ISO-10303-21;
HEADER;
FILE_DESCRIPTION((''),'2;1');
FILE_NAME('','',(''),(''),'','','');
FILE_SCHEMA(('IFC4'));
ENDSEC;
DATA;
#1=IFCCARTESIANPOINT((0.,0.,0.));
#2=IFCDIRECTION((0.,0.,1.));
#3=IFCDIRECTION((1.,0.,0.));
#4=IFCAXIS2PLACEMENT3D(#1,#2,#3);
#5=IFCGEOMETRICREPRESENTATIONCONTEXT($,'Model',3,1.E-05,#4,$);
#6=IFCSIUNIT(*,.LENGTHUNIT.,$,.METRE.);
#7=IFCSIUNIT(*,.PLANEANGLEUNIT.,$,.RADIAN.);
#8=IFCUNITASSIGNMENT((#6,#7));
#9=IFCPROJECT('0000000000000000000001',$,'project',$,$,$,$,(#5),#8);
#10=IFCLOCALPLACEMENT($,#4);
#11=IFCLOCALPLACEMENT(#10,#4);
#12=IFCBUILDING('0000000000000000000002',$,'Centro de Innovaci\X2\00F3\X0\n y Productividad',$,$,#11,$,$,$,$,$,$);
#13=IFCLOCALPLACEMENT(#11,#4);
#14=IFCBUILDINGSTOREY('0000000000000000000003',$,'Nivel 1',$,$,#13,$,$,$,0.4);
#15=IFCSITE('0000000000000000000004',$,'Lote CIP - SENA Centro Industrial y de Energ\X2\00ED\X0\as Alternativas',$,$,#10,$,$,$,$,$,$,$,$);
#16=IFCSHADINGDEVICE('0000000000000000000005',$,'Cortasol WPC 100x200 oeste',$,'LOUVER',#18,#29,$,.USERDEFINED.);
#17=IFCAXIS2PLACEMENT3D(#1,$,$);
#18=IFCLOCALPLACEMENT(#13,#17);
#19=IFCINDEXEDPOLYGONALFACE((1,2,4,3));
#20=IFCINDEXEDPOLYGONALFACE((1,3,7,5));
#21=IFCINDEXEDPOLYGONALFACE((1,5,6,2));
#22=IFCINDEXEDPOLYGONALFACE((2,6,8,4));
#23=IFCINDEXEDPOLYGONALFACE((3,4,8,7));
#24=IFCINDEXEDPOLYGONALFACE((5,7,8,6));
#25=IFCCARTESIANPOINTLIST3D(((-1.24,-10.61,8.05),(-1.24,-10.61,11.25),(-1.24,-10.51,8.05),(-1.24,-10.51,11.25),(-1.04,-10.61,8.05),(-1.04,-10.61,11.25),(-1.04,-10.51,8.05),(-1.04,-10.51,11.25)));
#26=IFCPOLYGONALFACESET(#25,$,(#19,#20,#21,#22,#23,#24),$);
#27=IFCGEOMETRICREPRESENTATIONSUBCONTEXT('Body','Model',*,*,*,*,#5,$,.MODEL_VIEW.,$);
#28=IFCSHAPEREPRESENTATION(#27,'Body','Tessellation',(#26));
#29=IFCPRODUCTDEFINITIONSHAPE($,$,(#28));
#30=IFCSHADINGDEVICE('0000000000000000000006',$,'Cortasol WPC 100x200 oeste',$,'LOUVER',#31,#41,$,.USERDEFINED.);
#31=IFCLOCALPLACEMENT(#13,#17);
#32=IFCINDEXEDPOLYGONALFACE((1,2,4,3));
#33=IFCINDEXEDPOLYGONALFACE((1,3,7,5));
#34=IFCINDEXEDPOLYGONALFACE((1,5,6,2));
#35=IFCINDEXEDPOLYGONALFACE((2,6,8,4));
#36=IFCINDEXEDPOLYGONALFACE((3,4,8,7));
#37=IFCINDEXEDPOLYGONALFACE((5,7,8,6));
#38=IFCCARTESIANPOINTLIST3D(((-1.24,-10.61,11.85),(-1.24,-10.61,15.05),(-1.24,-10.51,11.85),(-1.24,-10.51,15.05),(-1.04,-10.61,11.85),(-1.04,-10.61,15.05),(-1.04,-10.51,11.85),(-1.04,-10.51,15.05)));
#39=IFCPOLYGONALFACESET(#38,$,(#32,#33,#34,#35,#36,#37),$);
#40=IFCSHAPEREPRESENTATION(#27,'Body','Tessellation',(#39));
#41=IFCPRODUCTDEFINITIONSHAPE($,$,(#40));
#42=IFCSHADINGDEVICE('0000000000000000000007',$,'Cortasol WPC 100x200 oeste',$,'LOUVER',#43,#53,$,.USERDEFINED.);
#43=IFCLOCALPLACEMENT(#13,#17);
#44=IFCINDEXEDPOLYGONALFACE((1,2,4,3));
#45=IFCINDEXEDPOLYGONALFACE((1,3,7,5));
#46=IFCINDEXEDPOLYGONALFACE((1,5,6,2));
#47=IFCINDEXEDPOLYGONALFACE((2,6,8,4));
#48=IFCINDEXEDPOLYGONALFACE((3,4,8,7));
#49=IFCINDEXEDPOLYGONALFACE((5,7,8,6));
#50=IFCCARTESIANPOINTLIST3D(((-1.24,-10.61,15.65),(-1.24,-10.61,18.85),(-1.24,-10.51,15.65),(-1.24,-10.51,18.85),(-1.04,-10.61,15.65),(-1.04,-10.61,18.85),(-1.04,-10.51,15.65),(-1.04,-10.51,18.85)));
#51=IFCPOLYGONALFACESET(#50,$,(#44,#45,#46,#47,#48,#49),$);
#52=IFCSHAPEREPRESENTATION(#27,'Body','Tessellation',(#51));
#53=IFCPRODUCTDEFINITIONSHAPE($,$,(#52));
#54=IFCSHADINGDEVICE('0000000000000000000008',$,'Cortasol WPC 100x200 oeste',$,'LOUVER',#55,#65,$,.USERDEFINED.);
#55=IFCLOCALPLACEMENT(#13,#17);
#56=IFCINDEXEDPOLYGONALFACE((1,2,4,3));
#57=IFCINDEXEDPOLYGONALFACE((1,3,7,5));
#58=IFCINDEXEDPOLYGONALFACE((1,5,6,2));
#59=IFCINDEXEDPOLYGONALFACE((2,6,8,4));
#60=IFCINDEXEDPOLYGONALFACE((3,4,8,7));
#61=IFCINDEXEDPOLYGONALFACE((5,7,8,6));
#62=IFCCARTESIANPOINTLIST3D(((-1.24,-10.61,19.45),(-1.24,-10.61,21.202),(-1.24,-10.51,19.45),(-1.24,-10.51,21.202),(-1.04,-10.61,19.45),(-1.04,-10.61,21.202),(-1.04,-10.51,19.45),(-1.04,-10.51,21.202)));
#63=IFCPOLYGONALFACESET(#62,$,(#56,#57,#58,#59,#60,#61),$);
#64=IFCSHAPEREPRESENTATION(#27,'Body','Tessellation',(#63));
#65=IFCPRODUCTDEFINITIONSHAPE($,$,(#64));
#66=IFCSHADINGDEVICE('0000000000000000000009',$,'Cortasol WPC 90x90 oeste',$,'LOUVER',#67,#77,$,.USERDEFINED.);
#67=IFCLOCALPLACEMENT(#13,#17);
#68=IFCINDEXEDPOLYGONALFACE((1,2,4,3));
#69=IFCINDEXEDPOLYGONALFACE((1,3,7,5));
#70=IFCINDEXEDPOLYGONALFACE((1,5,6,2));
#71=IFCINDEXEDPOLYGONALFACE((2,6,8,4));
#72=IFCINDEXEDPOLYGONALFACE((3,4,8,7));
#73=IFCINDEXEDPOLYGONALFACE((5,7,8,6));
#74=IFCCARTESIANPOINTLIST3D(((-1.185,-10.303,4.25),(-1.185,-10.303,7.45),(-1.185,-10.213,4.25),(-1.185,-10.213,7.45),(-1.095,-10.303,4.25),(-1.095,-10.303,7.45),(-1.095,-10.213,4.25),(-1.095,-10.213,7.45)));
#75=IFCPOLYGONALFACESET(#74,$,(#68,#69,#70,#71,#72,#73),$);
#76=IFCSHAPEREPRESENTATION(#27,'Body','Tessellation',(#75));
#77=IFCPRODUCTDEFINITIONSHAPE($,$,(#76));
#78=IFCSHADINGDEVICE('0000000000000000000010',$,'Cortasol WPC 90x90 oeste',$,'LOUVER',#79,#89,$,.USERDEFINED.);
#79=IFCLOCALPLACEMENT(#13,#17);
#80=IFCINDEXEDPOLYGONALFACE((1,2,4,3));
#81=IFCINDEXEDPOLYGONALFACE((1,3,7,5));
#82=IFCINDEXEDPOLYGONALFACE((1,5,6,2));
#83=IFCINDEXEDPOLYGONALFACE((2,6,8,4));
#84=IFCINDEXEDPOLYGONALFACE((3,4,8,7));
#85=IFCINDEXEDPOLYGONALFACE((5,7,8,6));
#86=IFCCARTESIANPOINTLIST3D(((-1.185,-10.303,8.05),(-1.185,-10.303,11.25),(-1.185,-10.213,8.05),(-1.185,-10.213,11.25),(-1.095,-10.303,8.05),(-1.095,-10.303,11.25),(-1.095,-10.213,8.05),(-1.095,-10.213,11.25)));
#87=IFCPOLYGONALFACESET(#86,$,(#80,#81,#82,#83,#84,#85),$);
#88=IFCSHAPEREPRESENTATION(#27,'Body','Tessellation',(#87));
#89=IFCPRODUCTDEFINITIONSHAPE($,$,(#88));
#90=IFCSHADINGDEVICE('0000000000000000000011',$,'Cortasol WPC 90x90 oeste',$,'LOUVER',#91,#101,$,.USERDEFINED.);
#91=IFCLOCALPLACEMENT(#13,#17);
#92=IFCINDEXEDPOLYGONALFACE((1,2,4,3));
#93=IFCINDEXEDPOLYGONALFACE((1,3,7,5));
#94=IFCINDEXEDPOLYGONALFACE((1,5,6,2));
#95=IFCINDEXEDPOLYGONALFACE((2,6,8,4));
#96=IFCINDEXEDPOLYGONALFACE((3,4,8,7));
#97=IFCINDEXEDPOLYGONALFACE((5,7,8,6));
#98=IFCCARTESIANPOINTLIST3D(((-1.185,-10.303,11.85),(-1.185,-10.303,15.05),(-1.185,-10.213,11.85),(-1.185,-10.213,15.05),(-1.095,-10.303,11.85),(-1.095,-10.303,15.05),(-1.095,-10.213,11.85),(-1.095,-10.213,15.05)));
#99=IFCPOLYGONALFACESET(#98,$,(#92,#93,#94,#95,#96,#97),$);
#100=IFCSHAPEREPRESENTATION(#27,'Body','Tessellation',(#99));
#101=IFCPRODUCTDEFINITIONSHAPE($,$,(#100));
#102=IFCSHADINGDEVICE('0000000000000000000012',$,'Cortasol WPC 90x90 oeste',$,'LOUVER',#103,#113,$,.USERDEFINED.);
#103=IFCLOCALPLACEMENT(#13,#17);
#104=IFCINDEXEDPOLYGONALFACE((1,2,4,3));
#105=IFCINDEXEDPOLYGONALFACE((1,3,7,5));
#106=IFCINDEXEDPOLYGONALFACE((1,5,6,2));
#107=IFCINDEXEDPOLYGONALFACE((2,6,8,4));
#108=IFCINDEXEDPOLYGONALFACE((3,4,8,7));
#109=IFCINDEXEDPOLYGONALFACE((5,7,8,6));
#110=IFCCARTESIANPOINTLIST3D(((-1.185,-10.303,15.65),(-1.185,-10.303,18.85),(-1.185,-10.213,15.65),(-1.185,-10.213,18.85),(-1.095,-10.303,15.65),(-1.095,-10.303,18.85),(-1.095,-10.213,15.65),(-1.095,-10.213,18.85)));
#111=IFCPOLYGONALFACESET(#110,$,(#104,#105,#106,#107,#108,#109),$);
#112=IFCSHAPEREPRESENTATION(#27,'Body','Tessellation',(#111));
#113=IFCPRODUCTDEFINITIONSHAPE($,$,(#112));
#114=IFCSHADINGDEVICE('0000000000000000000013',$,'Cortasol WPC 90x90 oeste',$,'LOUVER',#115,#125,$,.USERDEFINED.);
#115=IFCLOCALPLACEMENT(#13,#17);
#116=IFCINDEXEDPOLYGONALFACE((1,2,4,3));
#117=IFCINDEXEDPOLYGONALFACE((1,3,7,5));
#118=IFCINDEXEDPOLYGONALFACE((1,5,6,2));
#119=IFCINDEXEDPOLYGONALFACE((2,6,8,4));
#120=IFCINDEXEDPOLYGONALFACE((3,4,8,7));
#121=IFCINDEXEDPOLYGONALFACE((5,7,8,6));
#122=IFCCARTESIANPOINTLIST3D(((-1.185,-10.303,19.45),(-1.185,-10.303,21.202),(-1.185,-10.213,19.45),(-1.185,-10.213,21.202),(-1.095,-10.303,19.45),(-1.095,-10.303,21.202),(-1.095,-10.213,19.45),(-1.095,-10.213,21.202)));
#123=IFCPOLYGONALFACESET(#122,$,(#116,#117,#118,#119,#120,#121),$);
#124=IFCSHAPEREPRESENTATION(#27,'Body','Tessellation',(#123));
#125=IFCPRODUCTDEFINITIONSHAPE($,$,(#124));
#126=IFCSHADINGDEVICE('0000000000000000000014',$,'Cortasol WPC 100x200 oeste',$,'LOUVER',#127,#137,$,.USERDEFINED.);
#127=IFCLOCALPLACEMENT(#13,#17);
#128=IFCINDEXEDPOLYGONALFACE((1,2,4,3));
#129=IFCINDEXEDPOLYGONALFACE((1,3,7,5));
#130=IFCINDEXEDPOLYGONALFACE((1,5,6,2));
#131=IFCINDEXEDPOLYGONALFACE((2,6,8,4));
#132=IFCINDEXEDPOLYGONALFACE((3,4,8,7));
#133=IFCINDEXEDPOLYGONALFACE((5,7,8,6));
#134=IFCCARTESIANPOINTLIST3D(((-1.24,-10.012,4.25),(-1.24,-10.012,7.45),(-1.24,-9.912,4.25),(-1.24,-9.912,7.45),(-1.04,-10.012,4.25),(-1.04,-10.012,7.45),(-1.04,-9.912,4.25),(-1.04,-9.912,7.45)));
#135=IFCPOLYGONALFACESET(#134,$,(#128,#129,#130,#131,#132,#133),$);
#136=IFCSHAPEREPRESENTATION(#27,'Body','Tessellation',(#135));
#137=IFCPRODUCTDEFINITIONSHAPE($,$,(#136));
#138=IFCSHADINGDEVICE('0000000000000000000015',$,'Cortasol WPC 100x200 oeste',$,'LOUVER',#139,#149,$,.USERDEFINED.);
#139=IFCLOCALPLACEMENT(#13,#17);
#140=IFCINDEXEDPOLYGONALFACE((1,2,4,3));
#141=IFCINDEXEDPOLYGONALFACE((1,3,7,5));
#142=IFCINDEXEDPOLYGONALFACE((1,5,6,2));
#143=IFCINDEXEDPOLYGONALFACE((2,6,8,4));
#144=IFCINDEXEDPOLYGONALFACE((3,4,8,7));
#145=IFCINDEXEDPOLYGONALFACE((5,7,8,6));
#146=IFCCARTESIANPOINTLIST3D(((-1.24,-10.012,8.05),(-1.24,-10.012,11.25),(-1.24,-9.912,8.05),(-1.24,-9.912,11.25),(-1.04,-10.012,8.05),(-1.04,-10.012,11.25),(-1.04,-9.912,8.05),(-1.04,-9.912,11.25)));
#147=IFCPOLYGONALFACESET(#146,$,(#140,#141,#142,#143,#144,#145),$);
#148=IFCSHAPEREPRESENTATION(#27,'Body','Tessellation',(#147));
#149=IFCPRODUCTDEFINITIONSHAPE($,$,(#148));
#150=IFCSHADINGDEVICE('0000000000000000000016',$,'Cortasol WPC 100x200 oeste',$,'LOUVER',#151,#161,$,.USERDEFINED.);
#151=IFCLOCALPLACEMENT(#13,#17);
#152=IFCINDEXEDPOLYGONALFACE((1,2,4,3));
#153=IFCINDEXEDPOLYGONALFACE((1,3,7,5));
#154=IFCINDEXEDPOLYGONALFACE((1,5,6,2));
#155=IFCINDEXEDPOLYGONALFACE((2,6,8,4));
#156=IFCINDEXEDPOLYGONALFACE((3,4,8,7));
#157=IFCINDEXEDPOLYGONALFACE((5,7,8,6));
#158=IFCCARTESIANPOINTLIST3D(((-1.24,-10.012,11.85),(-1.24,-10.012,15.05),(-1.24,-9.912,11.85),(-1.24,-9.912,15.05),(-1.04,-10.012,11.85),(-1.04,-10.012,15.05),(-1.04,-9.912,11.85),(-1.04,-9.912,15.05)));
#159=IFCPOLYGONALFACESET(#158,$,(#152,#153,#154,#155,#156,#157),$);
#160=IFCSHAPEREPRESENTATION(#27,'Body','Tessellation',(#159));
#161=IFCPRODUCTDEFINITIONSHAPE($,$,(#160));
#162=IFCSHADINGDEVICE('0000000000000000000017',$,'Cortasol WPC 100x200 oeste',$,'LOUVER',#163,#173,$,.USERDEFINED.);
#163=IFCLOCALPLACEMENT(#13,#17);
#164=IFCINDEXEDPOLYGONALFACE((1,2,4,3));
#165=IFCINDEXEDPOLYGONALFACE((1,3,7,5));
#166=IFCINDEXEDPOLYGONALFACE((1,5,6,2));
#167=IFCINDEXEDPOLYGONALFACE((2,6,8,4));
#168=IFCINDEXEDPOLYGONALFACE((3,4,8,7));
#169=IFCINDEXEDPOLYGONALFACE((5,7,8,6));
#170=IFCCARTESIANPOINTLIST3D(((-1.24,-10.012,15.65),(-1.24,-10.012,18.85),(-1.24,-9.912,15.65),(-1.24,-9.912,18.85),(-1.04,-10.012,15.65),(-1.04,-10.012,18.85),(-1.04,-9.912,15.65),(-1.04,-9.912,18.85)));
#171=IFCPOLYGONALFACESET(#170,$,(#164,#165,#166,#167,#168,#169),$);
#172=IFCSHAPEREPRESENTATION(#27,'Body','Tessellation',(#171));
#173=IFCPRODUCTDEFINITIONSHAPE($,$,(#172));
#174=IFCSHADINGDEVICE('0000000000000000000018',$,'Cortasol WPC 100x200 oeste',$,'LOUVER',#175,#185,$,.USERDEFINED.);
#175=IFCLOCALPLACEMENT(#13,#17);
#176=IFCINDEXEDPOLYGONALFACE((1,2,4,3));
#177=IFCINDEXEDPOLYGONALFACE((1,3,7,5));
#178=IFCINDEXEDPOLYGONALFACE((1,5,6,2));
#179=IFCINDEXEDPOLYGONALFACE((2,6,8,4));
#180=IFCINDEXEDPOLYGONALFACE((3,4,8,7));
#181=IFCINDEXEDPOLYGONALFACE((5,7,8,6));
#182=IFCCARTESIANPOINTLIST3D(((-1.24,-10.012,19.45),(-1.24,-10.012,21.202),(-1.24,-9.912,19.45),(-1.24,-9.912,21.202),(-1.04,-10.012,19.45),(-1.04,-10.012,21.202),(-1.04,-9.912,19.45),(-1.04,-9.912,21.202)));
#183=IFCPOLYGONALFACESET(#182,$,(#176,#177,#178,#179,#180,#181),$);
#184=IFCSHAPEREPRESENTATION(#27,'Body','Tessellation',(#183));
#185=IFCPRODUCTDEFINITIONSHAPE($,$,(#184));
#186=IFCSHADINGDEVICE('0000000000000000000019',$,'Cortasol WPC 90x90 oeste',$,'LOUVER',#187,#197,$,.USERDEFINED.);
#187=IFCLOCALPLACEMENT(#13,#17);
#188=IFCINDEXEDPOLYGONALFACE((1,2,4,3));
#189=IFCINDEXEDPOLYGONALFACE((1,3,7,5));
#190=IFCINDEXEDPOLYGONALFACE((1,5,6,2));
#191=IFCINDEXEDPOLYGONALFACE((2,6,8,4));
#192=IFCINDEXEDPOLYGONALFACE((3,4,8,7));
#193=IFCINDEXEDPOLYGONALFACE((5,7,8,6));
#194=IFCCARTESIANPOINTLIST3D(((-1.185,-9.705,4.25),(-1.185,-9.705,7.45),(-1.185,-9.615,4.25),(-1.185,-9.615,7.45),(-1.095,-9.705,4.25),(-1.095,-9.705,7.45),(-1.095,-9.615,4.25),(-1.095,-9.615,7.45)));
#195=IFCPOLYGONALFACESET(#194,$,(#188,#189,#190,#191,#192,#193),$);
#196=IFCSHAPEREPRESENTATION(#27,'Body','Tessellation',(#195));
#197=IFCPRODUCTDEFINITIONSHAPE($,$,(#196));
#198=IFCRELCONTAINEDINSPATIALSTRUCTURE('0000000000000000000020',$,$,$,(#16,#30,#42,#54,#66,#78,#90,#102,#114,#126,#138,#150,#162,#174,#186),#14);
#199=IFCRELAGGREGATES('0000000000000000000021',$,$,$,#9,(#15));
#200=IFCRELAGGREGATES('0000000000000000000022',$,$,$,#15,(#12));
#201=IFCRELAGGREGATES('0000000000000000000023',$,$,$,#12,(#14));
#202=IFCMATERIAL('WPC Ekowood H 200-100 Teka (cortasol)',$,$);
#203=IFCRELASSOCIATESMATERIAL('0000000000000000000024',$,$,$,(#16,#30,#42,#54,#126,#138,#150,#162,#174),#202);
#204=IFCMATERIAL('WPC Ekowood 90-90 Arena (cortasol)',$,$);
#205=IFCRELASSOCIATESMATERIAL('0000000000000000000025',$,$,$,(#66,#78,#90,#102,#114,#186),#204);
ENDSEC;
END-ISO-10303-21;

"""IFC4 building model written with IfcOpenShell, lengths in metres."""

from ifc_helpers import new_model, si_unit, frame, origin_with_axes, place, context, subcontext, project, spatial, polyline, outline, extrude, material, element, save


model = new_model("IFC4")

# Units and contexts
model_context = context("Model", 3, precision=1e-05, world=origin_with_axes())
body_context = subcontext(model_context, "Body", "Model", "MODEL_VIEW")
ifc_project = project(units=[si_unit("LENGTHUNIT", "METRE"), si_unit("PLANEANGLEUNIT", "RADIAN")], contexts=[model_context])

# Site, building, storey
site_placement = place(None, origin_with_axes())
site = spatial("IfcSite", under=ifc_project, at=site_placement, Name="Lote CIP - SENA Centro Industrial y de Energías Alternativas")
building_placement = place(site_placement, origin_with_axes())
building = spatial("IfcBuilding", under=site, at=building_placement, Name="Centro de Innovación y Productividad")
storey_placement = place(building_placement, origin_with_axes())
storey = spatial("IfcBuildingStorey", under=building, at=storey_placement, Name="Nivel 1", Elevation=0.4)

# Shading devices
ifc_material_1 = material(Name="WPC Ekowood H 200-100 Teka (cortasol)")
shading_device_1_placement = place(storey_placement, origin_with_axes())
element("IfcShadingDevice", 1, at=shading_device_1_placement, inside=storey, material=ifc_material_1, Name="Cortasol WPC 100x200 oeste", ObjectType="LOUVER", PredefinedType="USERDEFINED", context=body_context, shape_type="SweptSolid", body=[
    extrude(outline(polyline([(-1.04, -10.61), (-1.24, -10.61), (-1.24, -10.51), (-1.04, -10.51), (-1.04, -10.61)])), frame((0.0, 0.0, 8.05)), (0.0, 0.0, 1.0), 3.2),
])
shading_device_2_placement = place(storey_placement, origin_with_axes())
element("IfcShadingDevice", 2, at=shading_device_2_placement, inside=storey, material=ifc_material_1, Name="Cortasol WPC 100x200 oeste", ObjectType="LOUVER", PredefinedType="USERDEFINED", context=body_context, shape_type="SweptSolid", body=[
    extrude(outline(polyline([(-1.04, -10.61), (-1.24, -10.61), (-1.24, -10.51), (-1.04, -10.51), (-1.04, -10.61)])), frame((0.0, 0.0, 11.85)), (0.0, 0.0, 1.0), 3.2),
])
shading_device_3_placement = place(storey_placement, origin_with_axes())
element("IfcShadingDevice", 3, at=shading_device_3_placement, inside=storey, material=ifc_material_1, Name="Cortasol WPC 100x200 oeste", ObjectType="LOUVER", PredefinedType="USERDEFINED", context=body_context, shape_type="SweptSolid", body=[
    extrude(outline(polyline([(-1.04, -10.61), (-1.24, -10.61), (-1.24, -10.51), (-1.04, -10.51), (-1.04, -10.61)])), frame((0.0, 0.0, 15.65)), (0.0, 0.0, 1.0), 3.2),
])
shading_device_4_placement = place(storey_placement, origin_with_axes())
element("IfcShadingDevice", 4, at=shading_device_4_placement, inside=storey, material=ifc_material_1, Name="Cortasol WPC 100x200 oeste", ObjectType="LOUVER", PredefinedType="USERDEFINED", context=body_context, shape_type="SweptSolid", body=[
    extrude(outline(polyline([(-1.04, -10.61), (-1.24, -10.61), (-1.24, -10.51), (-1.04, -10.51), (-1.04, -10.61)])), frame((0.0, 0.0, 19.45)), (0.0, 0.0, 1.0), 1.752),
])
ifc_material_2 = material(Name="WPC Ekowood 90-90 Arena (cortasol)")
shading_device_5_placement = place(storey_placement, origin_with_axes())
element("IfcShadingDevice", 5, at=shading_device_5_placement, inside=storey, material=ifc_material_2, Name="Cortasol WPC 90x90 oeste", ObjectType="LOUVER", PredefinedType="USERDEFINED", context=body_context, shape_type="SweptSolid", body=[
    extrude(outline(polyline([(-1.095, -10.303), (-1.185, -10.303), (-1.185, -10.213), (-1.095, -10.213), (-1.095, -10.303)])), frame((0.0, 0.0, 4.25)), (0.0, 0.0, 1.0), 3.2),
])
shading_device_6_placement = place(storey_placement, origin_with_axes())
element("IfcShadingDevice", 6, at=shading_device_6_placement, inside=storey, material=ifc_material_2, Name="Cortasol WPC 90x90 oeste", ObjectType="LOUVER", PredefinedType="USERDEFINED", context=body_context, shape_type="SweptSolid", body=[
    extrude(outline(polyline([(-1.095, -10.303), (-1.185, -10.303), (-1.185, -10.213), (-1.095, -10.213), (-1.095, -10.303)])), frame((0.0, 0.0, 8.05)), (0.0, 0.0, 1.0), 3.2),
])
shading_device_7_placement = place(storey_placement, origin_with_axes())
element("IfcShadingDevice", 7, at=shading_device_7_placement, inside=storey, material=ifc_material_2, Name="Cortasol WPC 90x90 oeste", ObjectType="LOUVER", PredefinedType="USERDEFINED", context=body_context, shape_type="SweptSolid", body=[
    extrude(outline(polyline([(-1.095, -10.303), (-1.185, -10.303), (-1.185, -10.213), (-1.095, -10.213), (-1.095, -10.303)])), frame((0.0, 0.0, 11.85)), (0.0, 0.0, 1.0), 3.2),
])
shading_device_8_placement = place(storey_placement, origin_with_axes())
element("IfcShadingDevice", 8, at=shading_device_8_placement, inside=storey, material=ifc_material_2, Name="Cortasol WPC 90x90 oeste", ObjectType="LOUVER", PredefinedType="USERDEFINED", context=body_context, shape_type="SweptSolid", body=[
    extrude(outline(polyline([(-1.095, -10.303), (-1.185, -10.303), (-1.185, -10.213), (-1.095, -10.213), (-1.095, -10.303)])), frame((0.0, 0.0, 15.65)), (0.0, 0.0, 1.0), 3.2),
])
shading_device_9_placement = place(storey_placement, origin_with_axes())
element("IfcShadingDevice", 9, at=shading_device_9_placement, inside=storey, material=ifc_material_2, Name="Cortasol WPC 90x90 oeste", ObjectType="LOUVER", PredefinedType="USERDEFINED", context=body_context, shape_type="SweptSolid", body=[
    extrude(outline(polyline([(-1.095, -10.303), (-1.185, -10.303), (-1.185, -10.213), (-1.095, -10.213), (-1.095, -10.303)])), frame((0.0, 0.0, 19.45)), (0.0, 0.0, 1.0), 1.752),
])
shading_device_10_placement = place(storey_placement, origin_with_axes())
element("IfcShadingDevice", 10, at=shading_device_10_placement, inside=storey, material=ifc_material_1, Name="Cortasol WPC 100x200 oeste", ObjectType="LOUVER", PredefinedType="USERDEFINED", context=body_context, shape_type="SweptSolid", body=[
    extrude(outline(polyline([(-1.04, -10.012), (-1.24, -10.012), (-1.24, -9.912), (-1.04, -9.912), (-1.04, -10.012)])), frame((0.0, 0.0, 4.25)), (0.0, 0.0, 1.0), 3.2),
])
shading_device_11_placement = place(storey_placement, origin_with_axes())
element("IfcShadingDevice", 11, at=shading_device_11_placement, inside=storey, material=ifc_material_1, Name="Cortasol WPC 100x200 oeste", ObjectType="LOUVER", PredefinedType="USERDEFINED", context=body_context, shape_type="SweptSolid", body=[
    extrude(outline(polyline([(-1.04, -10.012), (-1.24, -10.012), (-1.24, -9.912), (-1.04, -9.912), (-1.04, -10.012)])), frame((0.0, 0.0, 8.05)), (0.0, 0.0, 1.0), 3.2),
])
shading_device_12_placement = place(storey_placement, origin_with_axes())
element("IfcShadingDevice", 12, at=shading_device_12_placement, inside=storey, material=ifc_material_1, Name="Cortasol WPC 100x200 oeste", ObjectType="LOUVER", PredefinedType="USERDEFINED", context=body_context, shape_type="SweptSolid", body=[
    extrude(outline(polyline([(-1.04, -10.012), (-1.24, -10.012), (-1.24, -9.912), (-1.04, -9.912), (-1.04, -10.012)])), frame((0.0, 0.0, 11.85)), (0.0, 0.0, 1.0), 3.2),
])
shading_device_13_placement = place(storey_placement, origin_with_axes())
element("IfcShadingDevice", 13, at=shading_device_13_placement, inside=storey, material=ifc_material_1, Name="Cortasol WPC 100x200 oeste", ObjectType="LOUVER", PredefinedType="USERDEFINED", context=body_context, shape_type="SweptSolid", body=[
    extrude(outline(polyline([(-1.04, -10.012), (-1.24, -10.012), (-1.24, -9.912), (-1.04, -9.912), (-1.04, -10.012)])), frame((0.0, 0.0, 15.65)), (0.0, 0.0, 1.0), 3.2),
])
shading_device_14_placement = place(storey_placement, origin_with_axes())
element("IfcShadingDevice", 14, at=shading_device_14_placement, inside=storey, material=ifc_material_1, Name="Cortasol WPC 100x200 oeste", ObjectType="LOUVER", PredefinedType="USERDEFINED", context=body_context, shape_type="SweptSolid", body=[
    extrude(outline(polyline([(-1.04, -10.012), (-1.24, -10.012), (-1.24, -9.912), (-1.04, -9.912), (-1.04, -10.012)])), frame((0.0, 0.0, 19.45)), (0.0, 0.0, 1.0), 1.752),
])
shading_device_15_placement = place(storey_placement, origin_with_axes())
element("IfcShadingDevice", 15, at=shading_device_15_placement, inside=storey, material=ifc_material_2, Name="Cortasol WPC 90x90 oeste", ObjectType="LOUVER", PredefinedType="USERDEFINED", context=body_context, shape_type="SweptSolid", body=[
    extrude(outline(polyline([(-1.095, -9.705), (-1.185, -9.705), (-1.185, -9.615), (-1.095, -9.615), (-1.095, -9.705)])), frame((0.0, 0.0, 4.25)), (0.0, 0.0, 1.0), 3.2),
])

save(model, "model.ifc")
